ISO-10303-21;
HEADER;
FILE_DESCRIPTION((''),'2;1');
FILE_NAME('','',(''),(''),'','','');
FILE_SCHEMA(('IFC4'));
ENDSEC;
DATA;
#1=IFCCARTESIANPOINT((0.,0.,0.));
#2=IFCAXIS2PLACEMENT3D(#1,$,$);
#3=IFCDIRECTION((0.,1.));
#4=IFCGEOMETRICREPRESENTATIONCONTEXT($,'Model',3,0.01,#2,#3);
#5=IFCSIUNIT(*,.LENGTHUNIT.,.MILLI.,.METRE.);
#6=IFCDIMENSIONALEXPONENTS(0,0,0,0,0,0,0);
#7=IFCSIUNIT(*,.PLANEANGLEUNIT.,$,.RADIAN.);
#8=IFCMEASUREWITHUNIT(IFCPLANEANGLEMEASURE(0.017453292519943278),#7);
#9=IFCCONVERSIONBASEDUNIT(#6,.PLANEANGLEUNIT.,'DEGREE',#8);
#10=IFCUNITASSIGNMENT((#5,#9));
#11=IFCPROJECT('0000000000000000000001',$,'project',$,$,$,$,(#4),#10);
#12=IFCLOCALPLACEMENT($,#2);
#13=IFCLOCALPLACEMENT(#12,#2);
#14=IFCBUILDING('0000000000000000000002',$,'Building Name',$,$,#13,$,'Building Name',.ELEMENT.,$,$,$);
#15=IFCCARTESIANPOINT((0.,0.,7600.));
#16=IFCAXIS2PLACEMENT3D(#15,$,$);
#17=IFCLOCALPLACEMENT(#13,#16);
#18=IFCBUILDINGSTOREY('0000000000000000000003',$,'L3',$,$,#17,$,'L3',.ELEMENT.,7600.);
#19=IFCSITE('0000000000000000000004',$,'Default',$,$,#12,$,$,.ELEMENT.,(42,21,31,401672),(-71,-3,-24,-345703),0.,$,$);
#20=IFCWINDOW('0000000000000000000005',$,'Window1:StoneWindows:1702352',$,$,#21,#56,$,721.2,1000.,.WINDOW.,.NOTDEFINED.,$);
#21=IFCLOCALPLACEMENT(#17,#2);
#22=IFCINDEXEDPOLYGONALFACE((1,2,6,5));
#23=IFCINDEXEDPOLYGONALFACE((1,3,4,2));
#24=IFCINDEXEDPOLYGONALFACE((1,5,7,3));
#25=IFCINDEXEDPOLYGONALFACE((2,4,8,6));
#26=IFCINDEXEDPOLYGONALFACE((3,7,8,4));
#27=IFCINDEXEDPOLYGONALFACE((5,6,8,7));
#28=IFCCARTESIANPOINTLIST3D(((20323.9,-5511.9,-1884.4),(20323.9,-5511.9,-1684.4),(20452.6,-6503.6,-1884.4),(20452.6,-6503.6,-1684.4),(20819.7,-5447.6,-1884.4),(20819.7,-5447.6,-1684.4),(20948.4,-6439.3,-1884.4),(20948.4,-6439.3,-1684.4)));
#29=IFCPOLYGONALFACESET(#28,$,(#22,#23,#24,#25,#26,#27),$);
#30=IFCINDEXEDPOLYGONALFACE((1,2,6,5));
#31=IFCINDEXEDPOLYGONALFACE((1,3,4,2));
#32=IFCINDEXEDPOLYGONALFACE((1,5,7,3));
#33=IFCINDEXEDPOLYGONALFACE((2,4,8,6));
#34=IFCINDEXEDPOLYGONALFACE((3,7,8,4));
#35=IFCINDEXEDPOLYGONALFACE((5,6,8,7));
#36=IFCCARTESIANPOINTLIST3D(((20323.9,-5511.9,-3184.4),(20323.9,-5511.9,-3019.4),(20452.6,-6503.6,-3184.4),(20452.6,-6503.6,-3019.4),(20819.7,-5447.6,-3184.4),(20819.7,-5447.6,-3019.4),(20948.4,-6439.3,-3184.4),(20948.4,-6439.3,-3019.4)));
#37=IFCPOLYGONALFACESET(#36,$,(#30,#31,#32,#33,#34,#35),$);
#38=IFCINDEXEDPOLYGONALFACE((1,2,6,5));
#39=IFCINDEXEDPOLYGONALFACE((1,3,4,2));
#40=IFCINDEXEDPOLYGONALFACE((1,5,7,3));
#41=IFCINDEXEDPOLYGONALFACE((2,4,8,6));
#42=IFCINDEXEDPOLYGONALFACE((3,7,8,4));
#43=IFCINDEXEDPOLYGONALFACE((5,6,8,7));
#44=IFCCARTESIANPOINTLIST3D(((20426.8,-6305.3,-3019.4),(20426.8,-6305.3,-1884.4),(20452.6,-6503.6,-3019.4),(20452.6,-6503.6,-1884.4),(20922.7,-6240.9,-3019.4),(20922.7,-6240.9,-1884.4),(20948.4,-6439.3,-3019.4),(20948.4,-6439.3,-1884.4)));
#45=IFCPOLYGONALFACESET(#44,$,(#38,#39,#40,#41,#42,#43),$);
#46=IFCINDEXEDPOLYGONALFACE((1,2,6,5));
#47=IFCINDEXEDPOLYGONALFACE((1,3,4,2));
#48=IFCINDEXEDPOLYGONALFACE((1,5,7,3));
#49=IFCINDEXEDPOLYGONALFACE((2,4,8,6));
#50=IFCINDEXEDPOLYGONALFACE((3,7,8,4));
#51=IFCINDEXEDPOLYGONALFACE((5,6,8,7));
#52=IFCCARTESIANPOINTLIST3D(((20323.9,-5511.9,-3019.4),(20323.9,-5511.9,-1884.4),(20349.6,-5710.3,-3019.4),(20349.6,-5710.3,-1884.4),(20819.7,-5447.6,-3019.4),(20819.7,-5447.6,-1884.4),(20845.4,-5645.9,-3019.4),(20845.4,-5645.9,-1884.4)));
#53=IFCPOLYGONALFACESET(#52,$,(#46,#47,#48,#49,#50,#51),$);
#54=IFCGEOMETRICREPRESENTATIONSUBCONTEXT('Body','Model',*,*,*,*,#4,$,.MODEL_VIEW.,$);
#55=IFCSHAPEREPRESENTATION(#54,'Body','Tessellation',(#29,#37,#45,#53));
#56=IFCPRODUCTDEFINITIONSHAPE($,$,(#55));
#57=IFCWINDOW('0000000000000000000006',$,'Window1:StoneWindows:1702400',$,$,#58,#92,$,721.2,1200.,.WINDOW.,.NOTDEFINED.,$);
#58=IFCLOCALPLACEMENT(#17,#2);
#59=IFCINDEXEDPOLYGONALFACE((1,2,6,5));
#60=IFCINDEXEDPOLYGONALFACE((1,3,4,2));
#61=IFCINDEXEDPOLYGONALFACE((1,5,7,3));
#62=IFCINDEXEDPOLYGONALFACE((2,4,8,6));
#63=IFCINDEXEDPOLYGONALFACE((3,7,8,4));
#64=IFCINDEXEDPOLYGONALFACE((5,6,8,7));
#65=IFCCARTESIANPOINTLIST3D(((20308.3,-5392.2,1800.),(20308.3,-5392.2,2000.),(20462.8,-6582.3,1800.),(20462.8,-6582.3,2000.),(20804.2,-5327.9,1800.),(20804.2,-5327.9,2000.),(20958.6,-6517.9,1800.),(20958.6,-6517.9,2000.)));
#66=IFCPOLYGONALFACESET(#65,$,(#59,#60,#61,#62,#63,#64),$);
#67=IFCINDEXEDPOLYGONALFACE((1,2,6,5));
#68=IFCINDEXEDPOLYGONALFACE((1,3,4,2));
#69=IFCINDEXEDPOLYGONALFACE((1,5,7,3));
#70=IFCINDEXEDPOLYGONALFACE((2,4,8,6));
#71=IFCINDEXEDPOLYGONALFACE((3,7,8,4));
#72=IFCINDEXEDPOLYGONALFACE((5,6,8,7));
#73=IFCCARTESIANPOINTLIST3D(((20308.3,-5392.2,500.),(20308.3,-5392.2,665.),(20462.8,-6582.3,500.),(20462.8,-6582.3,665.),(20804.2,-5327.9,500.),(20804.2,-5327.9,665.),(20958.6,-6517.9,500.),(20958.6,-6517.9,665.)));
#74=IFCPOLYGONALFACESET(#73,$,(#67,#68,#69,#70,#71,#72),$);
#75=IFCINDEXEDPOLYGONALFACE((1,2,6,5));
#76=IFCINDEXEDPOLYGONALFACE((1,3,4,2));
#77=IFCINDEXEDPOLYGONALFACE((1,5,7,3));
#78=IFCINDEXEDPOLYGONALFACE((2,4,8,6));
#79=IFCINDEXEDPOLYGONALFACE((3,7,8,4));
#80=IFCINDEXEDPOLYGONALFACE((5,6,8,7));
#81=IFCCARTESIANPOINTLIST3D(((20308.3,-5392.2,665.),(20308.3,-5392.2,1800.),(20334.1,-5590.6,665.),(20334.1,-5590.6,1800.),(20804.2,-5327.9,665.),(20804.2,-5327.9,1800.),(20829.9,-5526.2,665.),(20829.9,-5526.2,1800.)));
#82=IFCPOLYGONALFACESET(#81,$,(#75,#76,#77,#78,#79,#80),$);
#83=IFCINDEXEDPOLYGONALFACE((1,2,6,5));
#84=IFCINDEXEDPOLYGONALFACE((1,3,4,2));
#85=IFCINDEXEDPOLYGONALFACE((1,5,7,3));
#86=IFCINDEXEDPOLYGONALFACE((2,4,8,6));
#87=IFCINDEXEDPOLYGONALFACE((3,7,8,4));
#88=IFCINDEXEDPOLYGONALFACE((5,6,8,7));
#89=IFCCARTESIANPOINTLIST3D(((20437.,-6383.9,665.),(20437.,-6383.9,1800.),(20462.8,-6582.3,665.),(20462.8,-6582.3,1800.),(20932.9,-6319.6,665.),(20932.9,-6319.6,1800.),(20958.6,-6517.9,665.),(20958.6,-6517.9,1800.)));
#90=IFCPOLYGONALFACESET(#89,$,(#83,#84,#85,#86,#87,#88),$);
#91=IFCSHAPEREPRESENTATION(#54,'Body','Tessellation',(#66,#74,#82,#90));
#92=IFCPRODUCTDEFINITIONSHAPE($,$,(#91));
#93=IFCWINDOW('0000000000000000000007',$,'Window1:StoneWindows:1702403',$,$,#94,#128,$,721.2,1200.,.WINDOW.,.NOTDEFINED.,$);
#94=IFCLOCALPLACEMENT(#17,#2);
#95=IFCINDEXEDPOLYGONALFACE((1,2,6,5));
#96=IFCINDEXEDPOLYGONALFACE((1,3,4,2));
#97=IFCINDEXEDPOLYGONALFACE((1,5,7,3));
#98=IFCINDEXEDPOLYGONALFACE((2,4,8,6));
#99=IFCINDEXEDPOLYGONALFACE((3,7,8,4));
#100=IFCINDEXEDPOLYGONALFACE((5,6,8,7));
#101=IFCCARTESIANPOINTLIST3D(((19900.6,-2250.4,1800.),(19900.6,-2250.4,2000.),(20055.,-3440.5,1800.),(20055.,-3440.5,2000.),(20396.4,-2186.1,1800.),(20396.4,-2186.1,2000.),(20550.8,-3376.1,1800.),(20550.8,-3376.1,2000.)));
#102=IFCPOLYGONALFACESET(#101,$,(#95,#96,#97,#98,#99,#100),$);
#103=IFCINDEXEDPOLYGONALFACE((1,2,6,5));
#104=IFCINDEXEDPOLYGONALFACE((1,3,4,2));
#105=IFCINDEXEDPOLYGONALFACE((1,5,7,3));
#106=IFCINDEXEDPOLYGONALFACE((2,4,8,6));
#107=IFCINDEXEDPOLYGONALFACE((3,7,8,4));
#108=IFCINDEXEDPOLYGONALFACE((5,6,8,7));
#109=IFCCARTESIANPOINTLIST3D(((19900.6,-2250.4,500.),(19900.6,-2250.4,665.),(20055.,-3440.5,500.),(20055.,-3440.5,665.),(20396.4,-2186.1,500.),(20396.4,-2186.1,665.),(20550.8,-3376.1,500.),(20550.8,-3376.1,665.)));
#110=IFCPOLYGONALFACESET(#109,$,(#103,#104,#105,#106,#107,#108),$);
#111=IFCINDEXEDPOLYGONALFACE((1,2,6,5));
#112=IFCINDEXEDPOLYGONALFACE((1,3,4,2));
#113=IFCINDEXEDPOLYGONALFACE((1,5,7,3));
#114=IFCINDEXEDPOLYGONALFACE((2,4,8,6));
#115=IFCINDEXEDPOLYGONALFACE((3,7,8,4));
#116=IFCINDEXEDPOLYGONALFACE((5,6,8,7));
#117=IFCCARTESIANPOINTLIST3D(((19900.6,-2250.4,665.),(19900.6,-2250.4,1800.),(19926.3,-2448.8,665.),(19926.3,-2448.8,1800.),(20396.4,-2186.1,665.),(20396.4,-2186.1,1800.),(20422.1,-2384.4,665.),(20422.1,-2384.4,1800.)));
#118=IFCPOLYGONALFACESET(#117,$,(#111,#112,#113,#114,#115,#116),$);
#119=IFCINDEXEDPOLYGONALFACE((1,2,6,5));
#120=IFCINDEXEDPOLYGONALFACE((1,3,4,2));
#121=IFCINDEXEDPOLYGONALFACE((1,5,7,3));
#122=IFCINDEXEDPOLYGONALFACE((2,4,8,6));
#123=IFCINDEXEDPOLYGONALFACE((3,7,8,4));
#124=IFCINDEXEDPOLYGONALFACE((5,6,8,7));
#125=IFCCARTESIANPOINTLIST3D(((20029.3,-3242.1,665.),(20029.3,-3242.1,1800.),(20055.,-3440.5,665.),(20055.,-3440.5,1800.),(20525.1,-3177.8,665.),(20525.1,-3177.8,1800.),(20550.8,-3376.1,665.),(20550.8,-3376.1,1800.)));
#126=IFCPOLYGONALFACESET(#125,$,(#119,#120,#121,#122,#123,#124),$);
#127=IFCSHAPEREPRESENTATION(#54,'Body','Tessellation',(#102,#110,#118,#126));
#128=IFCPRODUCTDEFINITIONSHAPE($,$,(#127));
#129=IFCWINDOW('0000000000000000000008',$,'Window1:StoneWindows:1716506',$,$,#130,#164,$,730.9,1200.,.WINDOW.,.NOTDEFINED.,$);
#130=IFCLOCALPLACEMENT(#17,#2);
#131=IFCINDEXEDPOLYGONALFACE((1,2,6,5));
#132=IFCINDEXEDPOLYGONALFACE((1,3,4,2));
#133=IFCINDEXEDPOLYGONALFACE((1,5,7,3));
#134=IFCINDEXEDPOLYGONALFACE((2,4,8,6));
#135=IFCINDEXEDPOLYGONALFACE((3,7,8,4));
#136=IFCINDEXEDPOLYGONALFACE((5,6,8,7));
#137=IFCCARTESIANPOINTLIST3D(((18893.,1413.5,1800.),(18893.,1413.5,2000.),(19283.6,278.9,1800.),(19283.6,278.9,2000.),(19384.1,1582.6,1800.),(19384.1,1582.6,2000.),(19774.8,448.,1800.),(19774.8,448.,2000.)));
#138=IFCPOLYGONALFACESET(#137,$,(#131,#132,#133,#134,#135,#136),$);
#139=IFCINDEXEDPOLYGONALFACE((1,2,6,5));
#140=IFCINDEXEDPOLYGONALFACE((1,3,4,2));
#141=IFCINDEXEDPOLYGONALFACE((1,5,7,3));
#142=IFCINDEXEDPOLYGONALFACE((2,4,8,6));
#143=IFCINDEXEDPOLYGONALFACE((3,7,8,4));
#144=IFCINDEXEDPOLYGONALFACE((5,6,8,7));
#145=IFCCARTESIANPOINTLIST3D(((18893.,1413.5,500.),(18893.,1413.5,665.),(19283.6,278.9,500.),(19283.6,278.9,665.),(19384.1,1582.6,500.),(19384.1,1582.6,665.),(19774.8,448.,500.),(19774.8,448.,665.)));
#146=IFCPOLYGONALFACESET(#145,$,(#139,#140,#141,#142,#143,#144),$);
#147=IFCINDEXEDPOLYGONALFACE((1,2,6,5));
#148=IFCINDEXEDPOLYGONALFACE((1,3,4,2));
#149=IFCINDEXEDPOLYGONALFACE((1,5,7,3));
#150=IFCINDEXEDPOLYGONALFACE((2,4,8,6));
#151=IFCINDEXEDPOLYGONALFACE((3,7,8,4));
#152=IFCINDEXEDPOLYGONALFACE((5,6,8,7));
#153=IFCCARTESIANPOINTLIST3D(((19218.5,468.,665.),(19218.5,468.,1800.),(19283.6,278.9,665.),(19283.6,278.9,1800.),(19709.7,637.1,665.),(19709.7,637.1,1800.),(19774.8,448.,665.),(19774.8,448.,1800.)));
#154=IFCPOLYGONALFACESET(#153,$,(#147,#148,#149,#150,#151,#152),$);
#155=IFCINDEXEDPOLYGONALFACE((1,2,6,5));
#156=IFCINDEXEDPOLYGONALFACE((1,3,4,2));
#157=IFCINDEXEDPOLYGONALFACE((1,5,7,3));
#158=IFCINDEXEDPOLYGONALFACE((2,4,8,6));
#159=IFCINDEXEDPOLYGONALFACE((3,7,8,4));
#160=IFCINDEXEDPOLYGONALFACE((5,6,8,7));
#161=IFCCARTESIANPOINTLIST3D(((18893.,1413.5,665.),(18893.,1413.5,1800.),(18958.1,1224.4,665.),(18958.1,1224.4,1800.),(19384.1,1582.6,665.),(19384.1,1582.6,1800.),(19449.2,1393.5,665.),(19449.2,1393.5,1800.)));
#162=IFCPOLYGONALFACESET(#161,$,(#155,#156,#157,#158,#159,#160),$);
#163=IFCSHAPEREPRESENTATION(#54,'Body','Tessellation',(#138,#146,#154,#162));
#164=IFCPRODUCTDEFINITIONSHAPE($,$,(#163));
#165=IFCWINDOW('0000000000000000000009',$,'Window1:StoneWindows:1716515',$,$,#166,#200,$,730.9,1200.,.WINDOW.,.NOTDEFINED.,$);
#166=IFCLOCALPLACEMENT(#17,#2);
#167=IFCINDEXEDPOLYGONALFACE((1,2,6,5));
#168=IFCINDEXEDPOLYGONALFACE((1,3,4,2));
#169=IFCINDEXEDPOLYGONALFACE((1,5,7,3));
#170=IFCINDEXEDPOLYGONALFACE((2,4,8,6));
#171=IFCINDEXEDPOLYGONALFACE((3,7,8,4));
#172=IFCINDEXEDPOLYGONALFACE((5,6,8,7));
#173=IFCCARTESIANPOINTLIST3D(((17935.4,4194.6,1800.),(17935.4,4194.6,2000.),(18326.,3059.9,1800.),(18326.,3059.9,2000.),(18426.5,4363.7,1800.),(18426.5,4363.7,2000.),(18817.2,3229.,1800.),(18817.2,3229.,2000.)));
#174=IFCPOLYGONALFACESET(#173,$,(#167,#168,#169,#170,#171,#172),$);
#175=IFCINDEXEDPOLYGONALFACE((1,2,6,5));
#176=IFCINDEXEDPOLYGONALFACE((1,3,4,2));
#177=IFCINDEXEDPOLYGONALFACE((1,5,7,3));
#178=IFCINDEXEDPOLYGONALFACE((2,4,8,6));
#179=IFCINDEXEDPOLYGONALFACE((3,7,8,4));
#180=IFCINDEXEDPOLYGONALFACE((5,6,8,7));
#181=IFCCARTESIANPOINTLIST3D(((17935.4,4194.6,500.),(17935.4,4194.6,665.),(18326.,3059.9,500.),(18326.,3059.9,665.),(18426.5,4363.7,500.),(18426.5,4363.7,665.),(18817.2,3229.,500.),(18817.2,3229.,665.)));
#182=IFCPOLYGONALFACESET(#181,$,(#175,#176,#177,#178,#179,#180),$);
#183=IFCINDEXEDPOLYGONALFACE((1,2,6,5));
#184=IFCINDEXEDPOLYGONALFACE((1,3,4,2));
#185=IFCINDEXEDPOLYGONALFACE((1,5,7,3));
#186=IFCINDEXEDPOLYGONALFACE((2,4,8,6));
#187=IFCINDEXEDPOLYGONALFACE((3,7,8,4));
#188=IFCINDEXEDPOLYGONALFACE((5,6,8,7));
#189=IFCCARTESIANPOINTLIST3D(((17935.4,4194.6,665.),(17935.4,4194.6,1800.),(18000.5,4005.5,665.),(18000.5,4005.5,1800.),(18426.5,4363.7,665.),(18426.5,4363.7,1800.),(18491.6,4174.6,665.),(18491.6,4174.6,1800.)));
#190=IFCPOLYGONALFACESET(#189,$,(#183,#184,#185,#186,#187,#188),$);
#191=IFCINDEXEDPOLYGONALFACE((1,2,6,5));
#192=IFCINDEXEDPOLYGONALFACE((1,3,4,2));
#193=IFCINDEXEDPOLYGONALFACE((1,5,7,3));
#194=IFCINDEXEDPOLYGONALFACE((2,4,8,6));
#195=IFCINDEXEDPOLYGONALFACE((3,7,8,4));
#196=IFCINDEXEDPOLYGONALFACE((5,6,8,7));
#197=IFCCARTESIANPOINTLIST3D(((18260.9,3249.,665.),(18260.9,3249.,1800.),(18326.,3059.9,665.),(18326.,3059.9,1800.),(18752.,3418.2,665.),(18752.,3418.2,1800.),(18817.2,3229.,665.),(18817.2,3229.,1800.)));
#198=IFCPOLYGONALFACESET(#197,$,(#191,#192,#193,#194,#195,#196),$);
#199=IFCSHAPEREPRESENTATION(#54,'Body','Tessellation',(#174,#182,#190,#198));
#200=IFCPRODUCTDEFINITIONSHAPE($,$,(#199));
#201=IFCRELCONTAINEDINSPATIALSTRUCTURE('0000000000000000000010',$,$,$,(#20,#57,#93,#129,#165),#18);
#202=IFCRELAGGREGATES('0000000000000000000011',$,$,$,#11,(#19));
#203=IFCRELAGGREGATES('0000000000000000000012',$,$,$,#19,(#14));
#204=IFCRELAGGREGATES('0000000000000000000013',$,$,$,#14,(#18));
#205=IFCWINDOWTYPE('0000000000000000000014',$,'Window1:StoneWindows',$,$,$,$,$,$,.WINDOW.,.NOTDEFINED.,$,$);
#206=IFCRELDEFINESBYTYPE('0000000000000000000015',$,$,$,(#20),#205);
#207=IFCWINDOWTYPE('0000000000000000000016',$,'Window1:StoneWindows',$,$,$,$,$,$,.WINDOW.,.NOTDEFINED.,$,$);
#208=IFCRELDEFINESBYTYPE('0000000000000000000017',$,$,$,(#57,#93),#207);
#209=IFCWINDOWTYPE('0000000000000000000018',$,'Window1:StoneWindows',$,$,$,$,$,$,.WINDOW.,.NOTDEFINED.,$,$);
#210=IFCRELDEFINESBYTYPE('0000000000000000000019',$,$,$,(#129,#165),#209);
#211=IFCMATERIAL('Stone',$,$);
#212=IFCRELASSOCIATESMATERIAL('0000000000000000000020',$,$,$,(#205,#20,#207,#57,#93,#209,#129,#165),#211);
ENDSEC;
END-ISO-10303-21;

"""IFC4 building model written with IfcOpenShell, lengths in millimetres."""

from ifc_helpers import new_model, entity, si_unit, converted_unit, direction, frame, origin, place, context, subcontext, project, spatial, indexed_curve, outline, extrude, source, transform, mapped, material, type_object, type_shapes, element, save


model = new_model("IFC4")

# Units and contexts
model_context = context("Model", 3, precision=0.01, world=origin(), true_north=direction((0.0, 1.0)))
body_context = subcontext(model_context, "Body", "Model", "MODEL_VIEW")
ifc_project = project(units=[si_unit("LENGTHUNIT", "METRE", prefix="MILLI"), converted_unit("PLANEANGLEUNIT", "DEGREE", entity("IfcPlaneAngleMeasure", 0.017453292519943278), si_unit("PLANEANGLEUNIT", "RADIAN"), dimensions=[0, 0, 0, 0, 0, 0, 0])], contexts=[model_context])

# Site, building, storey
site_placement = place(None, origin())
site = spatial("IfcSite", under=ifc_project, at=site_placement, Name="Default", CompositionType="ELEMENT", RefLatitude=(42, 21, 31, 401672), RefLongitude=(-71, -3, -24, -345703), RefElevation=0.0)
building_placement = place(site_placement, origin())
building = spatial("IfcBuilding", under=site, at=building_placement, Name="Building Name", LongName="Building Name", CompositionType="ELEMENT")
storey_placement = place(building_placement, frame((0.0, 0.0, 7600.0)))
storey = spatial("IfcBuildingStorey", under=building, at=storey_placement, Name="L3", LongName="L3", CompositionType="ELEMENT", Elevation=7600.0)

# Windows
ifc_material_1 = material(Name="Stone")
window_type_1 = type_object("IfcWindowType", Name="Window1:StoneWindows", PartitioningType="NOTDEFINED", PredefinedType="WINDOW", material=ifc_material_1)
shared_shape_1 = source(origin(), body_context, "Body", "SweptSolid", [
    extrude(outline(indexed_curve([(-250.0, -500.0), (250.0, -500.0), (250.0, 500.0), (-250.0, 500.0), (-250.0, -500.0)], self_intersect=False)), frame((0.0, 0.0, 2100.0), z_axis=(0.0, 0.0, 1.0), x_axis=(0.0, 1.0, 0.0)), (0.0, 0.0, 1.0), 200.0),
    extrude(outline(indexed_curve([(-250.0, -500.0), (250.0, -500.0), (250.0, 500.0), (-250.0, 500.0), (-250.0, -500.0)], self_intersect=False)), frame((0.0, 0.0, 800.0), z_axis=(0.0, 0.0, 1.0), x_axis=(0.0, 1.0, 0.0)), (0.0, 0.0, 1.0), 165.0),
    extrude(outline(indexed_curve([(-250.0, -100.0), (250.0, -100.0), (250.0, 100.0), (-250.0, 100.0), (-250.0, -100.0)], self_intersect=False)), frame((-400.0, 0.0, 965.0), z_axis=(0.0, 0.0, 1.0), x_axis=(0.0, 1.0, 0.0)), (0.0, 0.0, 1.0), 1135.0),
    extrude(outline(indexed_curve([(-250.0, -100.0), (250.0, -100.0), (250.0, 100.0), (-250.0, 100.0), (-250.0, -100.0)], self_intersect=False)), frame((400.0, 0.0, 965.0), z_axis=(0.0, 0.0, 1.0), x_axis=(0.0, 1.0, 0.0)), (0.0, 0.0, 1.0), 1135.0),
])
type_shapes(window_type_1, [shared_shape_1])
window_placement = place(storey_placement, frame((20636.1, -5975.6, -3984.4), z_axis=(0.0, 0.0, 1.0), x_axis=(-0.128709, 0.991682, 0.0)))
element("IfcWindow", 1, at=window_placement, inside=storey, type_object=window_type_1, material=ifc_material_1, Name="Window1:StoneWindows:1702352", OverallHeight=721.2, OverallWidth=1000.0, PartitioningType="NOTDEFINED", PredefinedType="WINDOW", context=body_context, shape_type="MappedRepresentation", body=[
    mapped(shared_shape_1, transform((0.0, 0.0, 0.0), scale=1.0)),
])
window_type_2 = type_object("IfcWindowType", Name="Window1:StoneWindows", PartitioningType="NOTDEFINED", PredefinedType="WINDOW", material=ifc_material_1)
shared_shape_2 = source(origin(), body_context, "Body", "SweptSolid", [
    extrude(outline(indexed_curve([(-250.0, -600.0), (250.0, -600.0), (250.0, 600.0), (-250.0, 600.0), (-250.0, -600.0)], self_intersect=False)), frame((0.0, 0.0, 2100.0), z_axis=(0.0, 0.0, 1.0), x_axis=(0.0, 1.0, 0.0)), (0.0, 0.0, 1.0), 200.0),
    extrude(outline(indexed_curve([(-250.0, -600.0), (250.0, -600.0), (250.0, 600.0), (-250.0, 600.0), (-250.0, -600.0)], self_intersect=False)), frame((0.0, 0.0, 800.0), z_axis=(0.0, 0.0, 1.0), x_axis=(0.0, 1.0, 0.0)), (0.0, 0.0, 1.0), 165.0),
    extrude(outline(indexed_curve([(-250.0, -100.0), (250.0, -100.0), (250.0, 100.0), (-250.0, 100.0), (-250.0, -100.0)], self_intersect=False)), frame((-500.0, 0.0, 965.0), z_axis=(0.0, 0.0, 1.0), x_axis=(0.0, 1.0, 0.0)), (0.0, 0.0, 1.0), 1135.0),
    extrude(outline(indexed_curve([(-250.0, -100.0), (250.0, -100.0), (250.0, 100.0), (-250.0, 100.0), (-250.0, -100.0)], self_intersect=False)), frame((500.0, 0.0, 965.0), z_axis=(0.0, 0.0, 1.0), x_axis=(0.0, 1.0, 0.0)), (0.0, 0.0, 1.0), 1135.0),
])
type_shapes(window_type_2, [shared_shape_2])
for number, where, z_axis, x_axis, name in (
    (2, (20633.5, -5955.1, -300.0), (0.0, 0.0, 1.0), (0.128709, -0.991682, 0.0), "Window1:StoneWindows:1702400"),
    (3, (20225.7, -2813.3, -300.0), (0.0, 0.0, 1.0), (0.128709, -0.991682, 0.0), "Window1:StoneWindows:1702403"),
):
    element("IfcWindow", number, at=place(storey_placement, frame(where, z_axis=z_axis, x_axis=x_axis)), inside=storey, type_object=window_type_2, material=ifc_material_1, Name=name, OverallHeight=721.2, OverallWidth=1200.0, PartitioningType="NOTDEFINED", PredefinedType="WINDOW", context=body_context, shape_type="MappedRepresentation", body=[
        mapped(shared_shape_2, transform((0.0, 0.0, 0.0), scale=1.0)),
    ])

# Windows
window_type_3 = type_object("IfcWindowType", Name="Window1:StoneWindows", PartitioningType="NOTDEFINED", PredefinedType="WINDOW", material=ifc_material_1)
shared_shape_3 = source(origin(), body_context, "Body", "SweptSolid", [
    extrude(outline(indexed_curve([(-259.7, -600.0), (259.7, -600.0), (259.7, 600.0), (-259.7, 600.0), (-259.7, -600.0)], self_intersect=False)), frame((0.0, 0.0, 2100.0), z_axis=(0.0, 0.0, 1.0), x_axis=(0.0, 1.0, 0.0)), (0.0, 0.0, 1.0), 200.0),
    extrude(outline(indexed_curve([(-259.7, -600.0), (259.7, -600.0), (259.7, 600.0), (-259.7, 600.0), (-259.7, -600.0)], self_intersect=False)), frame((0.0, 0.0, 800.0), z_axis=(0.0, 0.0, 1.0), x_axis=(0.0, 1.0, 0.0)), (0.0, 0.0, 1.0), 165.0),
    extrude(outline(indexed_curve([(-259.7, -100.0), (259.7, -100.0), (259.7, 100.0), (-259.7, 100.0), (-259.7, -100.0)], self_intersect=False)), frame((-500.0, 0.0, 965.0), z_axis=(0.0, 0.0, 1.0), x_axis=(0.0, 1.0, 0.0)), (0.0, 0.0, 1.0), 1135.0),
    extrude(outline(indexed_curve([(-259.7, -100.0), (259.7, -100.0), (259.7, 100.0), (-259.7, 100.0), (-259.7, -100.0)], self_intersect=False)), frame((500.0, 0.0, 965.0), z_axis=(0.0, 0.0, 1.0), x_axis=(0.0, 1.0, 0.0)), (0.0, 0.0, 1.0), 1135.0),
])
type_shapes(window_type_3, [shared_shape_3])
for number, where, z_axis, x_axis, name in (
    (4, (19333.9, 930.7, -300.0), (0.0, 0.0, 1.0), (-0.325568, 0.945519, 0.0), "Window1:StoneWindows:1716506"),
    (5, (18376.3, 3711.8, -300.0), (0.0, 0.0, 1.0), (0.325568, -0.945519, 0.0), "Window1:StoneWindows:1716515"),
):
    element("IfcWindow", number, at=place(storey_placement, frame(where, z_axis=z_axis, x_axis=x_axis)), inside=storey, type_object=window_type_3, material=ifc_material_1, Name=name, OverallHeight=730.9, OverallWidth=1200.0, PartitioningType="NOTDEFINED", PredefinedType="WINDOW", context=body_context, shape_type="MappedRepresentation", body=[
        mapped(shared_shape_3, transform((0.0, 0.0, 0.0), scale=1.0)),
    ])

save(model, "model.ifc")
